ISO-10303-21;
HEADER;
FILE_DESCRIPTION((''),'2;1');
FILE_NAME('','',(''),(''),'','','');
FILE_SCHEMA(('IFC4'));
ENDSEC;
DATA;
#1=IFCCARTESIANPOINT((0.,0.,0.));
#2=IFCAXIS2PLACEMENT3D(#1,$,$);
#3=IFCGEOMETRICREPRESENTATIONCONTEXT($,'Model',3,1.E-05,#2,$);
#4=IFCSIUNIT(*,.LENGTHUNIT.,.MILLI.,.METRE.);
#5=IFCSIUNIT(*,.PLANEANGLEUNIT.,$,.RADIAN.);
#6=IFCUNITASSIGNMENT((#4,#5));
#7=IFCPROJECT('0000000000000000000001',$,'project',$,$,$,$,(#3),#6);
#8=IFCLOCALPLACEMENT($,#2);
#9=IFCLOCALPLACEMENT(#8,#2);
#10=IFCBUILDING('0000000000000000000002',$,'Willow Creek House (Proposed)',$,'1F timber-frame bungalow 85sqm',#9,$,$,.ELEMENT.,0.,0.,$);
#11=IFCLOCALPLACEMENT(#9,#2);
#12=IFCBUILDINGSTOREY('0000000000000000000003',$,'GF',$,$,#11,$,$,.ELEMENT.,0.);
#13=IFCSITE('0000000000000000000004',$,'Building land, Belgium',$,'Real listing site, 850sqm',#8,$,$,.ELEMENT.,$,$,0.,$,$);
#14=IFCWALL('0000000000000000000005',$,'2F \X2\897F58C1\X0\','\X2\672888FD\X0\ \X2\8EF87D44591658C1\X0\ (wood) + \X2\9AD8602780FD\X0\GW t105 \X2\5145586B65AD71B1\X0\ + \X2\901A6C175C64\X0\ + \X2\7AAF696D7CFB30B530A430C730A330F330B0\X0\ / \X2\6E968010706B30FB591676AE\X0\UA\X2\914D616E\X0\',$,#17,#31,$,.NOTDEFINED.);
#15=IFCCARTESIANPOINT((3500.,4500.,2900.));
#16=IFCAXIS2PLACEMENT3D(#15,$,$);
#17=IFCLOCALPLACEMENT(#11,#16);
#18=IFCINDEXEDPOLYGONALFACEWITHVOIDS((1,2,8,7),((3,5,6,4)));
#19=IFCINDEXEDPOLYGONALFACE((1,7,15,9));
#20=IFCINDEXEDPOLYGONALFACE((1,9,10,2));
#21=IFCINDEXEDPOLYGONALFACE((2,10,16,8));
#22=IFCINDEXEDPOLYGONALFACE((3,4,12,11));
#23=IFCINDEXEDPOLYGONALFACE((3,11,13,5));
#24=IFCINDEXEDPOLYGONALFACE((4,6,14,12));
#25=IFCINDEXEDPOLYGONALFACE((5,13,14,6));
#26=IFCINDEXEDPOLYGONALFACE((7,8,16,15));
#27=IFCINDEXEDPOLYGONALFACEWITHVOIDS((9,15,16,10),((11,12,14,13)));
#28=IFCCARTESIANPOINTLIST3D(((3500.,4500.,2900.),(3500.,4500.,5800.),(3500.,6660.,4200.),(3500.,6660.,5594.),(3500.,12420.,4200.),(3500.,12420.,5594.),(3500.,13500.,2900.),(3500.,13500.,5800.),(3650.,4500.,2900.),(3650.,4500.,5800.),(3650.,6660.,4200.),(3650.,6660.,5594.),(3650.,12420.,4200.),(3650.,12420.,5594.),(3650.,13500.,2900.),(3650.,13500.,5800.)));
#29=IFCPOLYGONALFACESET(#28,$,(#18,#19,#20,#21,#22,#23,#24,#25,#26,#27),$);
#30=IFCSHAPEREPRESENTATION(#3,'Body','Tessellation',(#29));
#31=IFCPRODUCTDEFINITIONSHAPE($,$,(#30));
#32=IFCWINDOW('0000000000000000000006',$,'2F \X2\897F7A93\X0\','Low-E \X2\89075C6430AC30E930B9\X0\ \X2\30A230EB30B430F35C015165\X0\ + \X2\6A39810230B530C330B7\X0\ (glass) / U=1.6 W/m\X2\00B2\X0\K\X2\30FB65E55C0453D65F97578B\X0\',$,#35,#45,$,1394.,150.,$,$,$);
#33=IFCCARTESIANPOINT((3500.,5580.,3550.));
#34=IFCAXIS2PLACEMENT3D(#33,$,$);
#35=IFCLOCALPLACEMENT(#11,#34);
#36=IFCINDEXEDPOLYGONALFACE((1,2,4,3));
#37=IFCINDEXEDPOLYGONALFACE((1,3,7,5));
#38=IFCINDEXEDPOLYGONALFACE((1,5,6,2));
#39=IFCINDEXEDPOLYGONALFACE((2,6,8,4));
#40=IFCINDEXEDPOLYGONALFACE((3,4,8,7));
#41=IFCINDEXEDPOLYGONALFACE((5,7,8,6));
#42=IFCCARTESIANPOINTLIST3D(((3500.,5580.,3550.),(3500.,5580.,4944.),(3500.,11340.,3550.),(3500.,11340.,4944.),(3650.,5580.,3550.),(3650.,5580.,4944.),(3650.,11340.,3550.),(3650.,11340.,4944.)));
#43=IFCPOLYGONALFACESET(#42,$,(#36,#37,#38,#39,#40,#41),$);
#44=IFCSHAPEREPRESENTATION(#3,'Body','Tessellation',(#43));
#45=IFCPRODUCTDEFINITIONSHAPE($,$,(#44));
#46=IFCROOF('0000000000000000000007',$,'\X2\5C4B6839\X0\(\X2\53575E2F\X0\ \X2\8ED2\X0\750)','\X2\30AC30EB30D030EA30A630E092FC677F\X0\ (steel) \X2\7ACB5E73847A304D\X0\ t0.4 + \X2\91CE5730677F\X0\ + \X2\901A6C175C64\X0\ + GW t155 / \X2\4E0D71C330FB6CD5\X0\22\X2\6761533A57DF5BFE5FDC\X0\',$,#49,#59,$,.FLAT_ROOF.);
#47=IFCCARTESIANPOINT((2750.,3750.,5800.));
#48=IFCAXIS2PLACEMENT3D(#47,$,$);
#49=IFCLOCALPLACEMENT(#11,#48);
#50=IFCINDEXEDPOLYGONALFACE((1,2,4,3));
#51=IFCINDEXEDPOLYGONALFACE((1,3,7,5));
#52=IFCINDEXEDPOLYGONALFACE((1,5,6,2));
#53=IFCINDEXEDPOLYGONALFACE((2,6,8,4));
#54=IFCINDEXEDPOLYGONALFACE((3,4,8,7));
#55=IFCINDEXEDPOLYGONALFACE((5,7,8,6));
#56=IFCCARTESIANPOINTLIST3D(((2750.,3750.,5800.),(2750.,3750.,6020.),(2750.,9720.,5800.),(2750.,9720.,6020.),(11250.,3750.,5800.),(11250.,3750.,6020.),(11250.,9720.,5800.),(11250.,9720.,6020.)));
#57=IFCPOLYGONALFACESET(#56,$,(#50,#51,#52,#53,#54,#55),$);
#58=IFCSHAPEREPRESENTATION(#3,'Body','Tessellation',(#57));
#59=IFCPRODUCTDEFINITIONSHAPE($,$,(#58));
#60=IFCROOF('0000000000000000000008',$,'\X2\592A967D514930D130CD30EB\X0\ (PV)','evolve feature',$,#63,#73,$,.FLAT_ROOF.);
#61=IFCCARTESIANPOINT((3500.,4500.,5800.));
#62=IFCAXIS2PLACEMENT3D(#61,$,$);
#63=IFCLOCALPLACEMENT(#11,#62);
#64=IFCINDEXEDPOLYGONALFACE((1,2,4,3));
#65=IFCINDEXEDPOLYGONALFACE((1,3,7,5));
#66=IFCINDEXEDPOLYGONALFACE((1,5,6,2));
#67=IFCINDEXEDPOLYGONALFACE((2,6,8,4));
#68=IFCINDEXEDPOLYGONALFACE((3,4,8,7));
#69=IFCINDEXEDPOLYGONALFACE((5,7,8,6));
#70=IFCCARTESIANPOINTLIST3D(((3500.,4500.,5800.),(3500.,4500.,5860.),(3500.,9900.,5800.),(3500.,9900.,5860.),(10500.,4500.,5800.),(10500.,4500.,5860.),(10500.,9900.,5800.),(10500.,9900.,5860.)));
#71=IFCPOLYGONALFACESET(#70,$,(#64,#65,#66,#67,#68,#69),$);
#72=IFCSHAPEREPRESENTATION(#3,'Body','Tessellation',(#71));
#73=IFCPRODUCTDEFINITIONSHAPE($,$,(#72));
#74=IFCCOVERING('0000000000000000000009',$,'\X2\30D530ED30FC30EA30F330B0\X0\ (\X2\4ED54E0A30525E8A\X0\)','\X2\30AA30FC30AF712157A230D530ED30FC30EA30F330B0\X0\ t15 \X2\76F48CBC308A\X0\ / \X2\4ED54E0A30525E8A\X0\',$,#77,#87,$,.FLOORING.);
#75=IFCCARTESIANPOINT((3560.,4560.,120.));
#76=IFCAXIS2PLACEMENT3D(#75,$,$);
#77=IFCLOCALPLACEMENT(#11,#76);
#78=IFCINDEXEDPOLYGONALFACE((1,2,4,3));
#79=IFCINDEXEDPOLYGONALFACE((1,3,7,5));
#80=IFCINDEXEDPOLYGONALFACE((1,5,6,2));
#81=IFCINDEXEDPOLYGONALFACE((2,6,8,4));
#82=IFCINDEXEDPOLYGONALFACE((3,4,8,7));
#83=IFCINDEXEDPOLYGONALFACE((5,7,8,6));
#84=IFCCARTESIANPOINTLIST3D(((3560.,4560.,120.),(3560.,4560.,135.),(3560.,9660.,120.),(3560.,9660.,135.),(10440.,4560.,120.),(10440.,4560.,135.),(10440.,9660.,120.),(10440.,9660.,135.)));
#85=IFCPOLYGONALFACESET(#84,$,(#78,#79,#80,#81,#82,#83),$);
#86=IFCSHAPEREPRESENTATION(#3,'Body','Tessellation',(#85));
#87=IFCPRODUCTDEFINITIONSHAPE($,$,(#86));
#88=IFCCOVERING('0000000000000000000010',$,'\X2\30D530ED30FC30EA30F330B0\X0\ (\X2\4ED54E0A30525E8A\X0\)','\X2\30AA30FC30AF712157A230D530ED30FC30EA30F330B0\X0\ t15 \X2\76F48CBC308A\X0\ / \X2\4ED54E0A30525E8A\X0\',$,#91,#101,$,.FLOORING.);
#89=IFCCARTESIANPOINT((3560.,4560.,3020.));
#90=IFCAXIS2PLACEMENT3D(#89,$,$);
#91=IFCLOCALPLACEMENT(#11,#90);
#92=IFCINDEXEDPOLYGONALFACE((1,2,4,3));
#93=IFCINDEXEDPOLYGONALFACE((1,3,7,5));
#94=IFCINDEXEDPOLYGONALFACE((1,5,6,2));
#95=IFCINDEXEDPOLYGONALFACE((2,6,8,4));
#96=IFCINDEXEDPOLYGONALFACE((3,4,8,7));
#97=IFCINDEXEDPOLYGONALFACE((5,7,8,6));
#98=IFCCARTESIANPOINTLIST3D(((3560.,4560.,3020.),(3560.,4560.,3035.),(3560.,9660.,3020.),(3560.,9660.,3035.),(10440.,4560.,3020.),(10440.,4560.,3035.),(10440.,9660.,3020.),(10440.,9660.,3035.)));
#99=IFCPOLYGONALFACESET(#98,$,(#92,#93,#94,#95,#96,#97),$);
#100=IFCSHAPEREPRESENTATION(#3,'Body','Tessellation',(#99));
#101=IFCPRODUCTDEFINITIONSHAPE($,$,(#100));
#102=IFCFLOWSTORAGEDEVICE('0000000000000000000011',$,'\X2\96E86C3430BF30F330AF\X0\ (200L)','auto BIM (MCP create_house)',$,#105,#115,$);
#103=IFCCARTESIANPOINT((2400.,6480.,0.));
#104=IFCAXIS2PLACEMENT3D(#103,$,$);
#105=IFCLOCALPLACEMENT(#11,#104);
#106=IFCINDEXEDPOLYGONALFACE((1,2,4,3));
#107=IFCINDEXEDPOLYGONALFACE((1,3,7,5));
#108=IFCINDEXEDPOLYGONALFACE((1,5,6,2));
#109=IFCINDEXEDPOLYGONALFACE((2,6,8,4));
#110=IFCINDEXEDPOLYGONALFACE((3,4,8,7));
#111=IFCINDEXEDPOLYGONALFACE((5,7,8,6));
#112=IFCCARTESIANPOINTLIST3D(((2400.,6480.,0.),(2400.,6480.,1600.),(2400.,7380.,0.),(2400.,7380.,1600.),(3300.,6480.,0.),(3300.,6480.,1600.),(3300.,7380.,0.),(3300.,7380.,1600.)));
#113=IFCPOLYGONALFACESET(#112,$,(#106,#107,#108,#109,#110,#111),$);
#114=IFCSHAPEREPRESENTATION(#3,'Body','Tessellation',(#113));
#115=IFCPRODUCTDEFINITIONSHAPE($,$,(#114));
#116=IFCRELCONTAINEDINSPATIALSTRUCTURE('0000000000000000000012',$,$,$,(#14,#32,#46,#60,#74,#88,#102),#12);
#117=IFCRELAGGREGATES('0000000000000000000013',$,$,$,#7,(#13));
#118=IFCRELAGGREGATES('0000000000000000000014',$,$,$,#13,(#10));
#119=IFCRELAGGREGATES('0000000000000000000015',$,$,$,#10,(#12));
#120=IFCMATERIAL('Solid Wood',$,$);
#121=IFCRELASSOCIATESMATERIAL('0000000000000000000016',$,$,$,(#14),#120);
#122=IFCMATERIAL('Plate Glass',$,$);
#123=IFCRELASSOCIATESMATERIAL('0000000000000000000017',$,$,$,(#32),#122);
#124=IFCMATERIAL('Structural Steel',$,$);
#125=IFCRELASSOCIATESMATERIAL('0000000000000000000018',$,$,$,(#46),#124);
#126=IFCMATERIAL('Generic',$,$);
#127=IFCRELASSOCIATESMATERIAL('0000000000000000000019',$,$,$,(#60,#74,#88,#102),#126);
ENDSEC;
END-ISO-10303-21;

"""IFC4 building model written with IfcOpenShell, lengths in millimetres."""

from ifc_helpers import new_model, si_unit, frame, frame_2d, origin, place, context, project, spatial, rectangle, extrude, material, element, fill, save


model = new_model("IFC4")

# Units and contexts
model_context = context("Model", 3, precision=1e-05, world=origin())
ifc_project = project(units=[si_unit("LENGTHUNIT", "METRE", prefix="MILLI"), si_unit("PLANEANGLEUNIT", "RADIAN")], contexts=[model_context])

# Site, building, storey
site_placement = place(None, origin())
site = spatial("IfcSite", under=ifc_project, at=site_placement, Name="Building land, Belgium", ObjectType="Real listing site, 850sqm", CompositionType="ELEMENT", RefElevation=0.0)
building_placement = place(site_placement, origin())
building = spatial("IfcBuilding", under=site, at=building_placement, Name="Willow Creek House (Proposed)", ObjectType="1F timber-frame bungalow 85sqm", CompositionType="ELEMENT", ElevationOfRefHeight=0.0, ElevationOfTerrain=0.0)
storey_placement = place(building_placement, origin())
storey = spatial("IfcBuildingStorey", under=building, at=storey_placement, Name="GF", CompositionType="ELEMENT", Elevation=0.0)

# Shared definitions
ifc_material_1 = material(Name="Solid Wood")
ifc_material_2 = material(Name="Generic")

# Shared definitions
ifc_material_3 = material(Name="Plate Glass")

# Wall, opening, window
wall_1_placement = place(storey_placement, frame((3500.0, 4500.0, 2900.0)))
wall_1 = element("IfcWall", 1, at=wall_1_placement, inside=storey, material=ifc_material_1, Name="2F 西壁", Description="木製 軸組外壁 (wood) + 高性能GW t105 充填断熱 + 通気層 + 窯業系サイディング / 準耐火・外皮UA配慮", PredefinedType="NOTDEFINED", context=model_context, shape_type="SweptSolid", body=[
    extrude(rectangle(XDim=150.0, YDim=9000.0, at=frame_2d((75.0, 4500.0))), frame((3500.0, 4500.0, 2900.0)), (0.0, 0.0, 1.0), 2900.0),
])
opening_1_placement = place(storey_placement, frame((3500.0, 5580.0, 3550.0)))
opening_1 = element("IfcOpeningElement", 2, at=opening_1_placement, cuts=wall_1, PredefinedType="NOTDEFINED", context=model_context, shape_type="SweptSolid", body=[
    extrude(rectangle(XDim=150.0, YDim=5760.0, at=frame_2d((75.0, 2880.0))), frame((3500.0, 5580.0, 3550.0)), (0.0, 0.0, 1.0), 1394.0),
])
window_1_placement = place(storey_placement, frame((3500.0, 5580.0, 3550.0)))
window_1 = element("IfcWindow", 3, at=window_1_placement, inside=storey, material=ifc_material_3, Name="2F 西窓", Description="Low-E 複層ガラス アルゴン封入 + 樹脂サッシ (glass) / U=1.6 W/m²K・日射取得型", OverallHeight=1394.0, OverallWidth=150.0, context=model_context, shape_type="SweptSolid", body=[
    extrude(rectangle(XDim=150.0, YDim=5760.0, at=frame_2d((75.0, 2880.0))), frame((3500.0, 5580.0, 3550.0)), (0.0, 0.0, 1.0), 1394.0),
])
fill(opening_1, window_1)

# Roofs
ifc_material_4 = material(Name="Structural Steel")
for number, where, name in (
    (4, (2750.0, 3750.0, 5800.0), "屋根(南帯 軒750)"),
):
    element("IfcRoof", number, at=place(storey_placement, frame(where)), inside=storey, material=ifc_material_4, Name=name, Description="ガルバリウム鋼板 (steel) 立平葺き t0.4 + 野地板 + 通気層 + GW t155 / 不燃・法22条区域対応", PredefinedType="FLAT_ROOF", context=model_context, shape_type="SweptSolid", body=[
        extrude(rectangle(XDim=8500.0, YDim=5970.0, at=frame_2d((4250.0, 2985.0))), frame((2750.0, 3750.0, 5800.0)), (0.0, 0.0, 1.0), 220.0),
    ])
roof_placement = place(storey_placement, frame((3500.0, 4500.0, 5800.0)))
element("IfcRoof", 5, at=roof_placement, inside=storey, material=ifc_material_2, Name="太陽光パネル (PV)", Description="evolve feature", PredefinedType="FLAT_ROOF", context=model_context, shape_type="SweptSolid", body=[
    extrude(rectangle(XDim=7000.0, YDim=5400.0, at=frame_2d((3500.0, 2700.0))), frame((3500.0, 4500.0, 5800.0)), (0.0, 0.0, 1.0), 60.0),
])

# Coverings
covering_1_placement = place(storey_placement, frame((3560.0, 4560.0, 120.0)))
element("IfcCovering", 6, at=covering_1_placement, inside=storey, material=ifc_material_2, Name="フローリング (仕上げ床)", Description="オーク無垢フローリング t15 直貼り / 仕上げ床", PredefinedType="FLOORING", context=model_context, shape_type="SweptSolid", body=[
    extrude(rectangle(XDim=6880.0, YDim=5100.0, at=frame_2d((3440.0, 2550.0))), frame((3560.0, 4560.0, 120.0)), (0.0, 0.0, 1.0), 15.0),
])
covering_2_placement = place(storey_placement, frame((3560.0, 4560.0, 3020.0)))
element("IfcCovering", 7, at=covering_2_placement, inside=storey, material=ifc_material_2, Name="フローリング (仕上げ床)", Description="オーク無垢フローリング t15 直貼り / 仕上げ床", PredefinedType="FLOORING", context=model_context, shape_type="SweptSolid", body=[
    extrude(rectangle(XDim=6880.0, YDim=5100.0, at=frame_2d((3440.0, 2550.0))), frame((3560.0, 4560.0, 3020.0)), (0.0, 0.0, 1.0), 15.0),
])

# Flow storage device
flow_storage_device_placement = place(storey_placement, frame((2400.0, 6480.0, 0.0)))
element("IfcFlowStorageDevice", 8, at=flow_storage_device_placement, inside=storey, material=ifc_material_2, Name="雨水タンク (200L)", Description="auto BIM (MCP create_house)", context=model_context, shape_type="SweptSolid", body=[
    extrude(rectangle(XDim=900.0, YDim=900.0, at=frame_2d((450.0, 450.0))), frame((2400.0, 6480.0, 0.0)), (0.0, 0.0, 1.0), 1600.0),
])

save(model, "model.ifc")
